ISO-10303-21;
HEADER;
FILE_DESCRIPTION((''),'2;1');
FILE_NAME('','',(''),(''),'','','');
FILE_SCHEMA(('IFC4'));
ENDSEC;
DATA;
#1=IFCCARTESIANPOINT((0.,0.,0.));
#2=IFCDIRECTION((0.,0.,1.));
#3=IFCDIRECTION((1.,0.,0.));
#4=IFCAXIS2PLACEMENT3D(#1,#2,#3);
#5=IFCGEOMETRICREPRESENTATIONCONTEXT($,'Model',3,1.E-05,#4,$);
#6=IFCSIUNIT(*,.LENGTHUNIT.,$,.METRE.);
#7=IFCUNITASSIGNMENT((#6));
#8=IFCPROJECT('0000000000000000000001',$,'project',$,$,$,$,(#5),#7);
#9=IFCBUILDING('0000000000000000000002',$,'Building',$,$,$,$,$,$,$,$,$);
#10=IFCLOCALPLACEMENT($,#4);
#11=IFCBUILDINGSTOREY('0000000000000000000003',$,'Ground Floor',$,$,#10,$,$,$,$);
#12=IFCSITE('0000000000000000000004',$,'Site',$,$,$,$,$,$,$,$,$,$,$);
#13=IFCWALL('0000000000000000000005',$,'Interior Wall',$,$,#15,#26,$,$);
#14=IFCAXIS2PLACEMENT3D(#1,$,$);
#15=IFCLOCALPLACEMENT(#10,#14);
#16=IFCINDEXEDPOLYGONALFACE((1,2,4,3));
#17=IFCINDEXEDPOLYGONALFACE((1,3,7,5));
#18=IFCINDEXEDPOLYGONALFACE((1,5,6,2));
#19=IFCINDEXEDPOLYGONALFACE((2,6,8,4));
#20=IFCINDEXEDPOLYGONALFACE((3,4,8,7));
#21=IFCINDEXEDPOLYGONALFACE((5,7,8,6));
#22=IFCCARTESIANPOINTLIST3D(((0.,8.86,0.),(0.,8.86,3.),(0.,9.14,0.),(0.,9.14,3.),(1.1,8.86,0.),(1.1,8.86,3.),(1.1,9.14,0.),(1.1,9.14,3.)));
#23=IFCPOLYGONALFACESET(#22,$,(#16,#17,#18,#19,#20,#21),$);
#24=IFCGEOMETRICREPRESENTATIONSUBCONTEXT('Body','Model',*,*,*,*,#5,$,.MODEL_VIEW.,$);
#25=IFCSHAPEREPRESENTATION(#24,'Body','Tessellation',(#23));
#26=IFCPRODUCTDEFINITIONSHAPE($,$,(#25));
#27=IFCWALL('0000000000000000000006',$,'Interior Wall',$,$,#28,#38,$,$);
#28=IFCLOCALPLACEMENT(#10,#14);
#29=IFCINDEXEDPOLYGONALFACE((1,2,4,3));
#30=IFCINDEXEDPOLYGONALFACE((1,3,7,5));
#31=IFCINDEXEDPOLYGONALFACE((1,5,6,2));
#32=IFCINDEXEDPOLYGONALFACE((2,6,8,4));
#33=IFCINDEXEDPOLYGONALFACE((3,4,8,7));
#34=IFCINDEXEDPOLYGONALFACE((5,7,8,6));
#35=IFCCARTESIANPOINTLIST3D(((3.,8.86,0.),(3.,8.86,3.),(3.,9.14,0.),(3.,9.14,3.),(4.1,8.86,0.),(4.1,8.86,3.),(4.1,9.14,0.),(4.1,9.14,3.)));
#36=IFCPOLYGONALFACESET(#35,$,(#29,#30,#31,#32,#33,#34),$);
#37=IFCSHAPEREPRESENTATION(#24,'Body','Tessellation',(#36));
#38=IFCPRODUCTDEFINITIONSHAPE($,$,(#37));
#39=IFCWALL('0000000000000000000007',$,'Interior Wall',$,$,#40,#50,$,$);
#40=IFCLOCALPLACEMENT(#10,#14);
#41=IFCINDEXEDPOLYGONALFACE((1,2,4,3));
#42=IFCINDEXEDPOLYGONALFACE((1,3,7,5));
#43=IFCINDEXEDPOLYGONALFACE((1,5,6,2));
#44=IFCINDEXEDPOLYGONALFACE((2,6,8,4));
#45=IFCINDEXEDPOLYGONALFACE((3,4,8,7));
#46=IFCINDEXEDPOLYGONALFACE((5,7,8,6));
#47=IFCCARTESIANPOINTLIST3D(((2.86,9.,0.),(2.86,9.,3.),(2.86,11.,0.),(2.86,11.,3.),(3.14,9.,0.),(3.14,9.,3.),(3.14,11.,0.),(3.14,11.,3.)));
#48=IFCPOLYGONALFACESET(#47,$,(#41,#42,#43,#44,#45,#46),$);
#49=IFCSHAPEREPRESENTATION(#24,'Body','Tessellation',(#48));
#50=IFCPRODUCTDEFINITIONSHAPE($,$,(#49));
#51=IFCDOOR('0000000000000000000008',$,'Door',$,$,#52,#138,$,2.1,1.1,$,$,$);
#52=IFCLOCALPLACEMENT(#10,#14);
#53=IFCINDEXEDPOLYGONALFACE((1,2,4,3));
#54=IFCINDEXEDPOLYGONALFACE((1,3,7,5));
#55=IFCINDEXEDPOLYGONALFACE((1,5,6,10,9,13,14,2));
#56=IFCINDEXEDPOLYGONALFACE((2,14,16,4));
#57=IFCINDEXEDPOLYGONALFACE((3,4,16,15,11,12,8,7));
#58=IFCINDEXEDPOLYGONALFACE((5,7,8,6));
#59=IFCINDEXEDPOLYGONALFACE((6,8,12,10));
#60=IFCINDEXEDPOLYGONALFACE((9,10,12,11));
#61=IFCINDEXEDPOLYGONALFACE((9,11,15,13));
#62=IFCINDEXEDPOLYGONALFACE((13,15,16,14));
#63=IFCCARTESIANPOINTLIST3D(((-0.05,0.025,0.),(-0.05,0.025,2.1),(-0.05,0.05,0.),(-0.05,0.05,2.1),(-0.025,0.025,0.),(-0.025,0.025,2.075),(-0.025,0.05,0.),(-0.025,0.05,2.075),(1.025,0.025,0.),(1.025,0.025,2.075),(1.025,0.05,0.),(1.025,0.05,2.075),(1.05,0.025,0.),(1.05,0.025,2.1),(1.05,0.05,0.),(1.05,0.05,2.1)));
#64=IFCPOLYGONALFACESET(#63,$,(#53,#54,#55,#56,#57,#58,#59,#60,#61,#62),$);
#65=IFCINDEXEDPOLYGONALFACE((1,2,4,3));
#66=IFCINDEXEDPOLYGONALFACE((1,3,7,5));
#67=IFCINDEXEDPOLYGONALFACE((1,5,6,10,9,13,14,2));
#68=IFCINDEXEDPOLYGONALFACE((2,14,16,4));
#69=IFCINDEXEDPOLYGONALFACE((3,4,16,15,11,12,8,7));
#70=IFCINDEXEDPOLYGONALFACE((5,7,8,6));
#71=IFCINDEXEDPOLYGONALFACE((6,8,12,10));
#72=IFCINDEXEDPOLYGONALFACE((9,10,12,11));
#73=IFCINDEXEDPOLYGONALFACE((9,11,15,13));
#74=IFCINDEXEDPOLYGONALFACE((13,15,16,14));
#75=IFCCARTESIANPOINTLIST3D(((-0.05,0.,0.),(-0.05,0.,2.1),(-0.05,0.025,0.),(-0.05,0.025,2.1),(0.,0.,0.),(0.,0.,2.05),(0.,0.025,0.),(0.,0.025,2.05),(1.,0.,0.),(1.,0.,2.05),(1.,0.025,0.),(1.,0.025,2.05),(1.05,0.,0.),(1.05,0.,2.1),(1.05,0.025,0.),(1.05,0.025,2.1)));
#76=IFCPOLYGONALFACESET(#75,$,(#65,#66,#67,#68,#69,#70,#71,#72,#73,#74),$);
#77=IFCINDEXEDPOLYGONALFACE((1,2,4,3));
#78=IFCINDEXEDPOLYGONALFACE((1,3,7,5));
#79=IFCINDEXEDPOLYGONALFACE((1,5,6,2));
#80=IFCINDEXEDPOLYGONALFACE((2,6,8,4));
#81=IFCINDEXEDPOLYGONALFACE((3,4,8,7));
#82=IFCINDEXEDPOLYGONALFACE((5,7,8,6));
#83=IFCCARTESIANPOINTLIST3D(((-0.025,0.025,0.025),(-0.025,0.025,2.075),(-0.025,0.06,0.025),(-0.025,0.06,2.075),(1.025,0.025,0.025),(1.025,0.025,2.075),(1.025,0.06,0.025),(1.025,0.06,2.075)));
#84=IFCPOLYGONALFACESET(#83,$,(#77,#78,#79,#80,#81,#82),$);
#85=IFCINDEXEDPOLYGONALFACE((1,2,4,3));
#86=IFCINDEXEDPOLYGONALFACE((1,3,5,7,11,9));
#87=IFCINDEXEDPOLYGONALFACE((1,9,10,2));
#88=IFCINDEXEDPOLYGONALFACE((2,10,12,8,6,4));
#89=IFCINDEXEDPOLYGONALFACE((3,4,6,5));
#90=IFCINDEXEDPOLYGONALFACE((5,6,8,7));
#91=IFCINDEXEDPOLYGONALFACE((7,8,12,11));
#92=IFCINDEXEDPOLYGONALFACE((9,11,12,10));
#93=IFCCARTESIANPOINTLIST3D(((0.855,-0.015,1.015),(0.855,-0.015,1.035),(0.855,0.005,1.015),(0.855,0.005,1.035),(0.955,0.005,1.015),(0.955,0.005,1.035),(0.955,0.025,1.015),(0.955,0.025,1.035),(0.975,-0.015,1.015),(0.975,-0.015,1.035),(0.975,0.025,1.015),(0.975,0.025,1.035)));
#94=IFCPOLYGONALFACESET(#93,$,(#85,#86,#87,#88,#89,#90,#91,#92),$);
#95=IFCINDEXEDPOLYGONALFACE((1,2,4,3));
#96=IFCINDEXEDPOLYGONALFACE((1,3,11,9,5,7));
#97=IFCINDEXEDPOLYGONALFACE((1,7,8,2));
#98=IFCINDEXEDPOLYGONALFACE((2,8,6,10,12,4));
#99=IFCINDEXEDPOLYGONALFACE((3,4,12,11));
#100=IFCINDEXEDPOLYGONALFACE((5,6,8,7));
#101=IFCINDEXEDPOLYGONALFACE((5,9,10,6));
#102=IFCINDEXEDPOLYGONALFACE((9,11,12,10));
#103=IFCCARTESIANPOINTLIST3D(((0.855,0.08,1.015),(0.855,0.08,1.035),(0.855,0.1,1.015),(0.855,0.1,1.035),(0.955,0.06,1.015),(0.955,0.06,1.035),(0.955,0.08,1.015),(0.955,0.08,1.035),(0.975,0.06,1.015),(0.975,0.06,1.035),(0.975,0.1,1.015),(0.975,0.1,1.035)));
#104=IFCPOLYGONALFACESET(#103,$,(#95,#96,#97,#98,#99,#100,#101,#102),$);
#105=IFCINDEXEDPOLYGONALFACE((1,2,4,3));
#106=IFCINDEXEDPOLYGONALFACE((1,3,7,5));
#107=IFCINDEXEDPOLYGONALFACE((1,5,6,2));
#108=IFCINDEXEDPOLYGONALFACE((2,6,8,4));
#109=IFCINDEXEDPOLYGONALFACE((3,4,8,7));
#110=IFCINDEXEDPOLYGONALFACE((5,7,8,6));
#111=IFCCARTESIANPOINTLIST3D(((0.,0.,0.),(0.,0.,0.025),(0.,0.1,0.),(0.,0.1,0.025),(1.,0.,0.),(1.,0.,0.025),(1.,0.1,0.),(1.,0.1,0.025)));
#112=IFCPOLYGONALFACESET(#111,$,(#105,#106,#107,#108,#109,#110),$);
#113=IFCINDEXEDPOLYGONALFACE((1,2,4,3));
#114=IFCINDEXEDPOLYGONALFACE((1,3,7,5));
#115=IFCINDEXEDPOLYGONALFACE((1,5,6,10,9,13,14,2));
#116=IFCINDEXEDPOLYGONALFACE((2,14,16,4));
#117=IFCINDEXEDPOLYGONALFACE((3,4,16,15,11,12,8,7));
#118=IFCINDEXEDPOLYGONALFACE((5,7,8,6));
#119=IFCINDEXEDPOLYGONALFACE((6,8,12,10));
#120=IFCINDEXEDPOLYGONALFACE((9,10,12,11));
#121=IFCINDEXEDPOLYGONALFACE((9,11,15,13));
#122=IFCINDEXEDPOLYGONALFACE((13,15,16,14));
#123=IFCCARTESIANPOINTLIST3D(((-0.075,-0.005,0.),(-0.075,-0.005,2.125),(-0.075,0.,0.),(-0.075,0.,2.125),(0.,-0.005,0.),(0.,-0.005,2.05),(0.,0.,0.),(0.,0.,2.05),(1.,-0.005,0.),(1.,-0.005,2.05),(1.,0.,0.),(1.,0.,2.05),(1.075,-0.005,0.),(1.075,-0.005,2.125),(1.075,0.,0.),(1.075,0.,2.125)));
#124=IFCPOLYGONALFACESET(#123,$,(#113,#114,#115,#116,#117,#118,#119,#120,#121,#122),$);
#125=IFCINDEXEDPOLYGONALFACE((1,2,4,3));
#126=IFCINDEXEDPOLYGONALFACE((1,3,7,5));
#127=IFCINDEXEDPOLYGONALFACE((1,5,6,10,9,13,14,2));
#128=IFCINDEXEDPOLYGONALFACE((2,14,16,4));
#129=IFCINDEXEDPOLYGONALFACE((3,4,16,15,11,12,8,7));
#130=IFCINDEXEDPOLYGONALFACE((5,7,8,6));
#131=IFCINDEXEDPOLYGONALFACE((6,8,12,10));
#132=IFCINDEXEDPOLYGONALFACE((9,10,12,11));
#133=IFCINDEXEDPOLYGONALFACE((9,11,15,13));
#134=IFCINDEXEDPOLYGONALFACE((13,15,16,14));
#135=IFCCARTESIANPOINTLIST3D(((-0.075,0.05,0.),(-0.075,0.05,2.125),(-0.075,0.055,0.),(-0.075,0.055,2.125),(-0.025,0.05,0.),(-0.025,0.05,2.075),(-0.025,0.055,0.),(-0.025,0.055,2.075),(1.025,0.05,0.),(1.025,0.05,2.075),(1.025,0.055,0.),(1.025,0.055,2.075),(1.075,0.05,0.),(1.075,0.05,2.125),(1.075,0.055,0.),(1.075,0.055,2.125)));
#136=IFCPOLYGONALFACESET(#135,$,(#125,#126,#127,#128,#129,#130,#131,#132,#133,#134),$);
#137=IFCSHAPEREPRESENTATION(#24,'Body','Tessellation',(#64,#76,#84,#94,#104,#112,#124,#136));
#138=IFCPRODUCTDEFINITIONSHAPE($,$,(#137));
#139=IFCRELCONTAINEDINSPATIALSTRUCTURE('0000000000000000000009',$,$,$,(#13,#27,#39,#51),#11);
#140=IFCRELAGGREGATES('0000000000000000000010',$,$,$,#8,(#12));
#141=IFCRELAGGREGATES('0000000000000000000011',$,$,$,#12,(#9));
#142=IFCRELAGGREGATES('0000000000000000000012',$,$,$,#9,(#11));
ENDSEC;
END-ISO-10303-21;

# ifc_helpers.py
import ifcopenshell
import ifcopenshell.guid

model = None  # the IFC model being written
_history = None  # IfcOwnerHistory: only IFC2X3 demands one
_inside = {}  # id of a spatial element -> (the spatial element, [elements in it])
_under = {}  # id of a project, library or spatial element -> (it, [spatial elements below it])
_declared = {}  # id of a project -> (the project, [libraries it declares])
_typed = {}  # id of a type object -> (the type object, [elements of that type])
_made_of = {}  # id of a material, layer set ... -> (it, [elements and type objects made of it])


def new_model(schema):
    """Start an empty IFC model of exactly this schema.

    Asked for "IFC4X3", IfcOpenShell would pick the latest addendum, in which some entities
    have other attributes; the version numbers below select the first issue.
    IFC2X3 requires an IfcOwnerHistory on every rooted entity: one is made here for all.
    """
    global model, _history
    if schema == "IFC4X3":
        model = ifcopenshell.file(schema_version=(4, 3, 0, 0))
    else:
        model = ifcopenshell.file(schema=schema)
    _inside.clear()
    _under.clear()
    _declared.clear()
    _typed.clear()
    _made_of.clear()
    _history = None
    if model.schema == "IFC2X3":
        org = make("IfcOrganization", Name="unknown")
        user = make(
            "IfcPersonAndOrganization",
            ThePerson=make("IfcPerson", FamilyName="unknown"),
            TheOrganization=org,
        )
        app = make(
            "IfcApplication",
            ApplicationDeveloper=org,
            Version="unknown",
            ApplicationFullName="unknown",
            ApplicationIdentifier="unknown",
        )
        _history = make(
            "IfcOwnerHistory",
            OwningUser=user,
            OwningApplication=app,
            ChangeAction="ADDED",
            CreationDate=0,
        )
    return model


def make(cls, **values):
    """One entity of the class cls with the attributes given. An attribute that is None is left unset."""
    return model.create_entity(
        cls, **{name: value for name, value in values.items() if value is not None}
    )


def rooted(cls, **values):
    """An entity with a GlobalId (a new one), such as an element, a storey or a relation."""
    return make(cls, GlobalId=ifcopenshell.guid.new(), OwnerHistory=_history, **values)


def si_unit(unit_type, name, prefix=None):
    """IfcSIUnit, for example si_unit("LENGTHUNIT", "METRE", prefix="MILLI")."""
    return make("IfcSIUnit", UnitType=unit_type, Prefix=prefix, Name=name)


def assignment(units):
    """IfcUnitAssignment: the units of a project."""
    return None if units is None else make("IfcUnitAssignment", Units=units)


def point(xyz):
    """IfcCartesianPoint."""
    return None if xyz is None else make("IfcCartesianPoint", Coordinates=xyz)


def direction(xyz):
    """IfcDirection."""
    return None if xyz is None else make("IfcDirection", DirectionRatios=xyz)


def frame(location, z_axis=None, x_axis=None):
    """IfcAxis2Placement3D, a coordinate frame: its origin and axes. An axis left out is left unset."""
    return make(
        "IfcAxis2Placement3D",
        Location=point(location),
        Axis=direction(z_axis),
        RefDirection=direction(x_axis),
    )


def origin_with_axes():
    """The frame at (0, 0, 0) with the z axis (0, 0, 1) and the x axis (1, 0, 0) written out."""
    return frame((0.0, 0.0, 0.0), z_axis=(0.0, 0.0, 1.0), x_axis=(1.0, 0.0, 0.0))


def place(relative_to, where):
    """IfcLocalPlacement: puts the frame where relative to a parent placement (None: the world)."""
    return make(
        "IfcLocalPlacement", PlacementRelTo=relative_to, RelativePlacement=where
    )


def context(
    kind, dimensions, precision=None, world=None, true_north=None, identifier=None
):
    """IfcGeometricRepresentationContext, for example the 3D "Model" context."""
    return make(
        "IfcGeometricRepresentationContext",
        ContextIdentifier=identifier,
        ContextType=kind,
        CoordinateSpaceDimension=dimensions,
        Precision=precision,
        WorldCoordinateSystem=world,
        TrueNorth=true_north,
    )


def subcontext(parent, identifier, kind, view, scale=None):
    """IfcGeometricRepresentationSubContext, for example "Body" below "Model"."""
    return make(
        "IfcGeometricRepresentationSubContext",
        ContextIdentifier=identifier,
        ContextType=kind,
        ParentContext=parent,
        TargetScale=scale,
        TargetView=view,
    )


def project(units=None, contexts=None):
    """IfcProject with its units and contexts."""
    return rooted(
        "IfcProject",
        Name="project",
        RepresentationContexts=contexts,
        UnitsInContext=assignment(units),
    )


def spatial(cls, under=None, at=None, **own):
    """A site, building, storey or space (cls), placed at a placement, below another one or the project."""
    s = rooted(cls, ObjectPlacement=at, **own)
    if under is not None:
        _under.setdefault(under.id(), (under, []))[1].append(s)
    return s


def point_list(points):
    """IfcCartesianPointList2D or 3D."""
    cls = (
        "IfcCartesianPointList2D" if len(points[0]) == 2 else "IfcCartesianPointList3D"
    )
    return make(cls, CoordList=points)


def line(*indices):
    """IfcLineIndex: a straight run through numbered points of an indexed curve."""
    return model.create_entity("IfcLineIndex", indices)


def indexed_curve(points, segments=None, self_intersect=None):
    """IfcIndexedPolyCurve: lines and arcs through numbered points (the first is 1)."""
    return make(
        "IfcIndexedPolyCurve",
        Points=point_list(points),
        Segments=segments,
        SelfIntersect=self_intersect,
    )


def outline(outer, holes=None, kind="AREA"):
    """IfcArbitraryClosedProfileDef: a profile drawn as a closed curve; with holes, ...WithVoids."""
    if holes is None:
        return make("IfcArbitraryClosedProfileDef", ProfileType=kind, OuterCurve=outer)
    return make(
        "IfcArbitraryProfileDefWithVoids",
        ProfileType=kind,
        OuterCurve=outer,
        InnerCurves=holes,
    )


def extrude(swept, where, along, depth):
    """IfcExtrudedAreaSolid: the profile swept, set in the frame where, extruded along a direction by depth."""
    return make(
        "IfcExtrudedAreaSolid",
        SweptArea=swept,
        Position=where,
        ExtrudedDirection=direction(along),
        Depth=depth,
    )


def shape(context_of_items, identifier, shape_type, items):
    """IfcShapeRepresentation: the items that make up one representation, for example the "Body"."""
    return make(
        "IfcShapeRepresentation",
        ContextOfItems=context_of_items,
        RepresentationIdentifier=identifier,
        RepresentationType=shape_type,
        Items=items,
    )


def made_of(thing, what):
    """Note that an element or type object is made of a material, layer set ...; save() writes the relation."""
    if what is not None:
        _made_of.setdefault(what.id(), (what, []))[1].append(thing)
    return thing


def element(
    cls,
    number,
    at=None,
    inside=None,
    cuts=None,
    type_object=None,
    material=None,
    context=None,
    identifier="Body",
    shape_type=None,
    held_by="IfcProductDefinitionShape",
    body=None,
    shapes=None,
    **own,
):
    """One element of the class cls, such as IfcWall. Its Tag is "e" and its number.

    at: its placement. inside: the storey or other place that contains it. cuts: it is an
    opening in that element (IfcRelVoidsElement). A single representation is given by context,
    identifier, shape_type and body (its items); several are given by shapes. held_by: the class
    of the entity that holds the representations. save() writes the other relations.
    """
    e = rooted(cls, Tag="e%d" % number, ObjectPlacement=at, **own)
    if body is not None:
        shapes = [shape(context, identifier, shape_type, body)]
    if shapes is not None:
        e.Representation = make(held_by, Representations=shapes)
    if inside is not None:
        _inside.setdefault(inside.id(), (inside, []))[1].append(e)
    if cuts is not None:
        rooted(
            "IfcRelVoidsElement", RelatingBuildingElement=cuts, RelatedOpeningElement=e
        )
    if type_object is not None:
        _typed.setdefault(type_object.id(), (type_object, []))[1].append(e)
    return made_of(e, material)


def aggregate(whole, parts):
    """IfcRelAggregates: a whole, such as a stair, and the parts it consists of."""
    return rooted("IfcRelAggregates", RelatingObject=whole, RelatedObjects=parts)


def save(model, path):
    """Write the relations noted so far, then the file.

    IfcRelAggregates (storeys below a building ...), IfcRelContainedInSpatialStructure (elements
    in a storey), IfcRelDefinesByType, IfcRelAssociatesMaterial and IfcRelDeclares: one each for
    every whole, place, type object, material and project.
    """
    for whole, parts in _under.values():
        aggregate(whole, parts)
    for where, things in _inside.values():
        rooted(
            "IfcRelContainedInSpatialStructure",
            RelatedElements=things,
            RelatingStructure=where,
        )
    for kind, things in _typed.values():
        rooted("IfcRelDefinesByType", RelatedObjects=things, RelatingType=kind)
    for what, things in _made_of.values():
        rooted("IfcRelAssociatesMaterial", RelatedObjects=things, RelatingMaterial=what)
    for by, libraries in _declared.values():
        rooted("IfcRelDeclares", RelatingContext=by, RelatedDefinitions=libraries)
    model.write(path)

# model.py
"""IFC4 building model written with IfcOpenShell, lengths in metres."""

from ifc_helpers import new_model, si_unit, frame, origin_with_axes, place, context, subcontext, project, spatial, line, indexed_curve, outline, extrude, element, save


model = new_model("IFC4")

# Units and contexts
model_context = context("Model", 3, precision=1e-05, world=origin_with_axes())
body_context = subcontext(model_context, "Body", "Model", "MODEL_VIEW")
ifc_project = project(units=[si_unit("LENGTHUNIT", "METRE")], contexts=[model_context])

# Site, building, storey
site = spatial("IfcSite", under=ifc_project, Name="Site")
building = spatial("IfcBuilding", under=site, Name="Building")
storey_placement = place(None, origin_with_axes())
storey = spatial("IfcBuildingStorey", under=building, at=storey_placement, Name="Ground Floor")

# Walls
for number, where, z_axis, x_axis, name in (
    (1, (1.1, 9.0, 0.0), (0.0, 0.0, 1.0), (-1.0, 0.0, 0.0), "Interior Wall"),
):
    element("IfcWall", number, at=place(storey_placement, frame(where, z_axis=z_axis, x_axis=x_axis)), inside=storey, Name=name, context=body_context, shape_type="SweptSolid", body=[
        extrude(outline(indexed_curve([(0.0, 0.0), (0.0, 0.28), (1.1, 0.28), (1.1, 0.0), (0.0, 0.0)], self_intersect=False)), frame((0.0, -0.14, 0.0), z_axis=(0.0, 0.0, 1.0), x_axis=(1.0, 0.0, 0.0)), (0.0, 0.0, 1.0), 3.0),
    ])
wall_1_placement = place(storey_placement, frame((4.1, 9.0, 0.0), z_axis=(0.0, 0.0, 1.0), x_axis=(-1.0, 0.0, 0.0)))
element("IfcWall", 2, at=wall_1_placement, inside=storey, Name="Interior Wall", context=body_context, shape_type="SweptSolid", body=[
    extrude(outline(indexed_curve([(0.0, 0.0), (0.0, 0.28), (1.1, 0.28), (1.1, 0.0), (0.0, 0.0)], self_intersect=False)), frame((0.0, -0.14, 0.0), z_axis=(0.0, 0.0, 1.0), x_axis=(1.0, 0.0, 0.0)), (0.0, 0.0, 1.0), 3.0),
])
wall_2_placement = place(storey_placement, frame((3.0, 9.0, 0.0), z_axis=(0.0, 0.0, 1.0), x_axis=(0.0, 1.0, 0.0)))
element("IfcWall", 3, at=wall_2_placement, inside=storey, Name="Interior Wall", context=body_context, shape_type="SweptSolid", body=[
    extrude(outline(indexed_curve([(0.0, 0.0), (0.0, 0.28), (2.0, 0.28), (2.0, 0.0), (0.0, 0.0)], self_intersect=False)), frame((0.0, -0.14, 0.0), z_axis=(0.0, 0.0, 1.0), x_axis=(1.0, 0.0, 0.0)), (0.0, 0.0, 1.0), 3.0),
])

# Door
door_1_placement = place(storey_placement, frame((-0.05, 0.0, 0.0), z_axis=(0.0, 0.0, 1.0), x_axis=(1.0, 0.0, 0.0)))
element("IfcDoor", 4, at=door_1_placement, inside=storey, Name="Door", OverallHeight=2.1, OverallWidth=1.1, context=body_context, shape_type="SweptSolid", body=[
    extrude(outline(indexed_curve([(0.0, 0.0), (0.0, 2.1), (1.1, 2.1), (1.1, 0.0), (1.075, 0.0), (1.075, 2.075), (0.025, 2.075), (0.025, 0.0)], segments=[line(1, 2, 3, 4, 5, 6, 7, 8, 1)])), frame((0.0, 0.025, 0.0), z_axis=(0.0, -1.0, 0.0), x_axis=(1.0, 0.0, 0.0)), (0.0, 0.0, -1.0), 0.025),
    extrude(outline(indexed_curve([(0.0, 0.0), (0.0, 2.1), (1.1, 2.1), (1.1, 0.0), (1.05, 0.0), (1.05, 2.05), (0.05, 2.05), (0.05, 0.0)], segments=[line(1, 2, 3, 4, 5, 6, 7, 8, 1)])), frame((0.0, 0.0, 0.0), z_axis=(0.0, -1.0, 0.0), x_axis=(1.0, 0.0, 0.0)), (0.0, 0.0, -1.0), 0.025),
    extrude(outline(indexed_curve([(0.0, 0.0), (1.05, 0.0), (1.05, 0.035), (0.0, 0.035)], segments=[line(1, 2, 3, 4, 1)])), frame((0.025, 0.025, 0.025), z_axis=(0.0, 0.0, 1.0), x_axis=(1.0, 0.0, 0.0)), (0.0, 0.0, 1.0), 2.05),
    extrude(outline(indexed_curve([(0.0, 0.0), (0.0, -0.04), (-0.12, -0.04), (-0.12, -0.02), (-0.02, -0.02), (-0.02, 0.0)], segments=[line(1, 2, 3, 4, 5, 6, 1)])), frame((1.025, 0.025, 1.015), z_axis=(0.0, 0.0, 1.0), x_axis=(1.0, 0.0, 0.0)), (0.0, 0.0, 1.0), 0.02),
    extrude(outline(indexed_curve([(0.0, 0.0), (0.0, 0.04), (-0.12, 0.04), (-0.12, 0.02), (-0.02, 0.02), (-0.02, 0.0)], segments=[line(1, 2, 3, 4, 5, 6, 1)])), frame((1.025, 0.06, 1.015), z_axis=(0.0, 0.0, 1.0), x_axis=(1.0, 0.0, 0.0)), (0.0, 0.0, 1.0), 0.02),
    extrude(outline(indexed_curve([(0.0, 0.0), (1.0, 0.0), (1.0, 0.1), (0.0, 0.1)], segments=[line(1, 2, 3, 4, 1)])), frame((0.05, 0.0, 0.0), z_axis=(0.0, 0.0, 1.0), x_axis=(1.0, 0.0, 0.0)), (0.0, 0.0, 1.0), 0.025),
    extrude(outline(indexed_curve([(0.0, 0.0), (0.0, 2.125), (1.15, 2.125), (1.15, 0.0), (1.075, 0.0), (1.075, 2.05), (0.075, 2.05), (0.075, 0.0)], segments=[line(1, 2, 3, 4, 5, 6, 7, 8, 1)])), frame((-0.025, -0.005, 0.0), z_axis=(0.0, -1.0, 0.0), x_axis=(1.0, 0.0, 0.0)), (0.0, 0.0, -1.0), 0.005),
    extrude(outline(indexed_curve([(0.0, 0.0), (0.0, 2.125), (1.15, 2.125), (1.15, 0.0), (1.1, 0.0), (1.1, 2.075), (0.05, 2.075), (0.05, 0.0)], segments=[line(1, 2, 3, 4, 5, 6, 7, 8, 1)])), frame((-0.025, 0.05, 0.0), z_axis=(0.0, -1.0, 0.0), x_axis=(1.0, 0.0, 0.0)), (0.0, 0.0, -1.0), 0.005),
])

save(model, "model.ifc")
